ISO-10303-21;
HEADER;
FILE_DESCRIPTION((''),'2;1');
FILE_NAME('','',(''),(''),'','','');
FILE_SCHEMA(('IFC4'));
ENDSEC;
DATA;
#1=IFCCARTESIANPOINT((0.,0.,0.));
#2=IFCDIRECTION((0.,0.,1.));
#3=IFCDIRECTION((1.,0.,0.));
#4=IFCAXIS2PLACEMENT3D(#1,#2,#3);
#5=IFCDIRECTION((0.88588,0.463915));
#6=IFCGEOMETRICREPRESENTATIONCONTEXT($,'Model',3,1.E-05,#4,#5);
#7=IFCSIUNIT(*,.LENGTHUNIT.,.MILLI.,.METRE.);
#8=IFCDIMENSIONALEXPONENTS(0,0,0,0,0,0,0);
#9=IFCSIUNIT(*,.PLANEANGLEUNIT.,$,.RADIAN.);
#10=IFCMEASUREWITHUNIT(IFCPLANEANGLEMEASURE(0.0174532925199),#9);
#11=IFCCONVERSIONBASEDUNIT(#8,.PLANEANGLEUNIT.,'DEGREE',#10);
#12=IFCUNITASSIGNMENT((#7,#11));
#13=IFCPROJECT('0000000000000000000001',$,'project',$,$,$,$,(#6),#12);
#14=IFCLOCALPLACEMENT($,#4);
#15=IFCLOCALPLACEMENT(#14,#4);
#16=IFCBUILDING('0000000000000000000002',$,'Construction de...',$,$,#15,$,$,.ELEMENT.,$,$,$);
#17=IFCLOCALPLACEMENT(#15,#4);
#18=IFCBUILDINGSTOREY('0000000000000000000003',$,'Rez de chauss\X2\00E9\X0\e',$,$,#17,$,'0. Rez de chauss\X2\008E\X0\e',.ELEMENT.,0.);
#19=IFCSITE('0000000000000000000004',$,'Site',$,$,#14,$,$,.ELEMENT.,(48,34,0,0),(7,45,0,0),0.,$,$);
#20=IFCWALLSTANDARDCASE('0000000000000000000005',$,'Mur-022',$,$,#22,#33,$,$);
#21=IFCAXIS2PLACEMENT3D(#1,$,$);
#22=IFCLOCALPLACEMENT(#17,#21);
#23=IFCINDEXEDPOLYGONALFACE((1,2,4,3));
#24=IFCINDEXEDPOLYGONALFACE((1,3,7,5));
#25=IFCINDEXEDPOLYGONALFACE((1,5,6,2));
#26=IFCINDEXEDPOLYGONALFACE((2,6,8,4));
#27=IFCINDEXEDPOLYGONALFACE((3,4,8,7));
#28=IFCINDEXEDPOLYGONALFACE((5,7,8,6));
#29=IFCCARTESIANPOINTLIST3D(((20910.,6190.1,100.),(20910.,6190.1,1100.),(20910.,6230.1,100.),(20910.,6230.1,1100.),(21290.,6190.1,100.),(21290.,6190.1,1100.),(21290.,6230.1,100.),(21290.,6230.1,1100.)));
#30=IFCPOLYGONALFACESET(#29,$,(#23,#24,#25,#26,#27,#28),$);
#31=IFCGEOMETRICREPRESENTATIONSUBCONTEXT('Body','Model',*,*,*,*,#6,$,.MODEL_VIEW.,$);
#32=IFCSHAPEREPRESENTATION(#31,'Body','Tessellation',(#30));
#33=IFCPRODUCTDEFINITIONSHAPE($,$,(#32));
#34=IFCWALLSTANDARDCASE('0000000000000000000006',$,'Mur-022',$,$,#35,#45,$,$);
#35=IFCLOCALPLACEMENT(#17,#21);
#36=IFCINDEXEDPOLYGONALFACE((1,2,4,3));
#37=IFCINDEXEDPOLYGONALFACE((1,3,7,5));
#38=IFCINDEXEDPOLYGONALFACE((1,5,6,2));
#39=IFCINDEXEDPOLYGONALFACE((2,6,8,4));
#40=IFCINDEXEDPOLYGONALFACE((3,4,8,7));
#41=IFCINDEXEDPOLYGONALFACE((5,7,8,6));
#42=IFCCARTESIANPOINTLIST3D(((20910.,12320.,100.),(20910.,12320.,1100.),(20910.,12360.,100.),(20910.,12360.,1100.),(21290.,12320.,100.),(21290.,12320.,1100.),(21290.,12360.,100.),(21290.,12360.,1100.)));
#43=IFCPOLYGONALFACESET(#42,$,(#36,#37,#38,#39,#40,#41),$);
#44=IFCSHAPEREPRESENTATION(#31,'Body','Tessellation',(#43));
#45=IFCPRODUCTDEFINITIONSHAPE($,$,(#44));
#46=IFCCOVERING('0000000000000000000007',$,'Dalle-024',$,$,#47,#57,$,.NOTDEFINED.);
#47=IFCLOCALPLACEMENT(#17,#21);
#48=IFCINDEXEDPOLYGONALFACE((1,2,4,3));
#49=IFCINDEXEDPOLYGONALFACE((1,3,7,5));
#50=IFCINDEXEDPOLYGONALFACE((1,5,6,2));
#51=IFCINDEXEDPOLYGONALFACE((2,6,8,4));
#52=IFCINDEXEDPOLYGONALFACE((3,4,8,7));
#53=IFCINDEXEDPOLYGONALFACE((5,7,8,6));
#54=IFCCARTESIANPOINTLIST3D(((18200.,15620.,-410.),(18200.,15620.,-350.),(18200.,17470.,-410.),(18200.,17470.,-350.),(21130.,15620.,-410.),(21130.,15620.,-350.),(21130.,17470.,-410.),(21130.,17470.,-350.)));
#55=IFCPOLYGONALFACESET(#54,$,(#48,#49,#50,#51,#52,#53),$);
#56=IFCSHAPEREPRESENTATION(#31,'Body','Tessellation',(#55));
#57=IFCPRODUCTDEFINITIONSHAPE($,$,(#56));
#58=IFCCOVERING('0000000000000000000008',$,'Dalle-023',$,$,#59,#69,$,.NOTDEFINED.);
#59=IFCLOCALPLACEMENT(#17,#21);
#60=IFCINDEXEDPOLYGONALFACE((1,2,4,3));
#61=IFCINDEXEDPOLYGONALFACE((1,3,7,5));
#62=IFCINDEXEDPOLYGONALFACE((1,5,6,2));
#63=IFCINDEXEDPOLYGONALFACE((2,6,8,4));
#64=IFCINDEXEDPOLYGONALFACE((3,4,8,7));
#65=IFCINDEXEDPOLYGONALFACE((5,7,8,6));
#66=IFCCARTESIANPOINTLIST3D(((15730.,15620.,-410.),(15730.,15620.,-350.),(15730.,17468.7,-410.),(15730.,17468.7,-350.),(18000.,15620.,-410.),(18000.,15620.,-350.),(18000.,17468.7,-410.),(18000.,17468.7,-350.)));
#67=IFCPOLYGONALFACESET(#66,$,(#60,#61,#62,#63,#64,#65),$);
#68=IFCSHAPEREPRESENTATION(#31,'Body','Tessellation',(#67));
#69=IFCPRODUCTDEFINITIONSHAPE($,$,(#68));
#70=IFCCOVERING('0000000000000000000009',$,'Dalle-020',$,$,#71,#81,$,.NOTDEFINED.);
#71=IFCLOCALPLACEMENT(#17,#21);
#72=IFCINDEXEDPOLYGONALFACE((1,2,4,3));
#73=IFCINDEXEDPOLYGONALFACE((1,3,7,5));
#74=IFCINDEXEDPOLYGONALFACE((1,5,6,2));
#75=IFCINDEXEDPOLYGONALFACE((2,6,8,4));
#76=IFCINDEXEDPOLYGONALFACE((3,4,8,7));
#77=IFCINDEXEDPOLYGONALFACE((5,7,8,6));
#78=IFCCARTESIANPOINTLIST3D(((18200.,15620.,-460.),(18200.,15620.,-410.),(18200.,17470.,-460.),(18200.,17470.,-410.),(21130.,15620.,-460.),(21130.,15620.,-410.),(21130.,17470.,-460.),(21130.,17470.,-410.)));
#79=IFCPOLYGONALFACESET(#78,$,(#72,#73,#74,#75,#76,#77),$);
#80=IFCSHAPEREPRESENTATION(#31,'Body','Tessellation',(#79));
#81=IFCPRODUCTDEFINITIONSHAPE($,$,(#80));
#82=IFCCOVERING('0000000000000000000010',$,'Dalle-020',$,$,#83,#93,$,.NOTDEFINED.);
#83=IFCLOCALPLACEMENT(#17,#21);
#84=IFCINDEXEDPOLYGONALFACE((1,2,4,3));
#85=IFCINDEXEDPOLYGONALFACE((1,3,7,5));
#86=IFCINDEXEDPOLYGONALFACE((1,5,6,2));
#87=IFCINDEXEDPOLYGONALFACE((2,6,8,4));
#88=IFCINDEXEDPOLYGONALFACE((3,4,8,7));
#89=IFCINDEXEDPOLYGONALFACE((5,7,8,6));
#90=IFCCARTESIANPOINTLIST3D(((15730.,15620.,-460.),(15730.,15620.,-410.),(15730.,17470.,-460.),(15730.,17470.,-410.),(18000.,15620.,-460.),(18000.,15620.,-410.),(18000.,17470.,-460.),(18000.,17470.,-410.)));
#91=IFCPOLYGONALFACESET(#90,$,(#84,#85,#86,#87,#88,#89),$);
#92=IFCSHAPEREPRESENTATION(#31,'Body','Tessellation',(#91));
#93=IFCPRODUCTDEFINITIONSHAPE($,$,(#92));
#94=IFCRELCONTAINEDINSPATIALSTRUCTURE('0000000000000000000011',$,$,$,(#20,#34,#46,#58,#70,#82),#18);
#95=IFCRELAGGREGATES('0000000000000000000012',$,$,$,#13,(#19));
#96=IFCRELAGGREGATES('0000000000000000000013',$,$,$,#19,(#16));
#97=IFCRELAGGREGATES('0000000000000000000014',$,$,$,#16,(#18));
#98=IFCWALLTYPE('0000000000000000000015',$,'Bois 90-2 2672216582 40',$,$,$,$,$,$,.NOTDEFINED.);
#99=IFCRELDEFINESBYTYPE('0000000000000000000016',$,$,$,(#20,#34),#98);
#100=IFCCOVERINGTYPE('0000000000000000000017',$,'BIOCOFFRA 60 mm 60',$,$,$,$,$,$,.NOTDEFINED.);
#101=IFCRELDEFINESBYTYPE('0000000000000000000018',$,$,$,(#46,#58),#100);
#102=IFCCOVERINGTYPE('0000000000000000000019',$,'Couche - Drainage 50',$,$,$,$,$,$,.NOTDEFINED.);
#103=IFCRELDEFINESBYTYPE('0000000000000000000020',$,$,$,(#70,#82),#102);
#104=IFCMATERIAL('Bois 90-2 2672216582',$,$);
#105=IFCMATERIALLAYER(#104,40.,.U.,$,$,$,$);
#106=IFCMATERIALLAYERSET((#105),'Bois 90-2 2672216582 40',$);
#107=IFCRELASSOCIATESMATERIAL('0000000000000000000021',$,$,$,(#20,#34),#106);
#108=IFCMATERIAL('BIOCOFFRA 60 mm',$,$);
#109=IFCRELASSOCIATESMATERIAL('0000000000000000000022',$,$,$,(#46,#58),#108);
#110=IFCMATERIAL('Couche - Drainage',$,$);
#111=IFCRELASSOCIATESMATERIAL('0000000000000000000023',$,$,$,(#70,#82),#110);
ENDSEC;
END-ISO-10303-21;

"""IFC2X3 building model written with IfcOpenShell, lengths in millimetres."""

from ifc_helpers import new_model, entity, si_unit, converted_unit, direction, frame, origin_with_axes, place, context, subcontext, project, spatial, polyline, outline, extrude, material, layer, layer_set, layer_usage, type_object, element, save


model = new_model("IFC2X3")

# Units and contexts
model_context = context("Model", 3, precision=1e-05, world=origin_with_axes(), true_north=direction((0.88588, 0.463915)))
body_context = subcontext(model_context, "Body", "Model", "MODEL_VIEW")
ifc_project = project(units=[si_unit("LENGTHUNIT", "METRE", prefix="MILLI"), converted_unit("PLANEANGLEUNIT", "DEGREE", entity("IfcPlaneAngleMeasure", 0.0174532925199), si_unit("PLANEANGLEUNIT", "RADIAN"), dimensions=[0, 0, 0, 0, 0, 0, 0])], contexts=[model_context])

# Site, building, storey
site_placement = place(None, origin_with_axes())
site = spatial("IfcSite", under=ifc_project, at=site_placement, Name="Site", CompositionType="ELEMENT", RefLatitude=(48, 34, 0, 0), RefLongitude=(7, 45, 0, 0), RefElevation=0.0)
building_placement = place(site_placement, origin_with_axes())
building = spatial("IfcBuilding", under=site, at=building_placement, Name="Construction de...", CompositionType="ELEMENT")
storey_placement = place(building_placement, origin_with_axes())
storey = spatial("IfcBuildingStorey", under=building, at=storey_placement, Name="Rez de chaussée", LongName="0. Rez de chauss\u008ee", CompositionType="ELEMENT", Elevation=0.0)

# Walls
ifc_material_1 = material(Name="Bois 90-2 2672216582")
ifc_layer_1 = layer(ifc_material_1, 40.0, ventilated="UNKNOWN")
ifc_layer_set_1 = layer_set([ifc_layer_1], Name="Bois 90-2 2672216582 40")
wall_type_1 = type_object("IfcWallType", Name="Bois 90-2 2672216582 40", PredefinedType="NOTDEFINED")
ifc_layer_usage_1 = layer_usage(ifc_layer_set_1, "AXIS2", "POSITIVE", -20.0)
wall_1_placement = place(storey_placement, frame((20910.0, 6210.1, 100.0), z_axis=(0.0, 0.0, 1.0), x_axis=(1.0, 0.0, 0.0)))
element("IfcWallStandardCase", 1, at=wall_1_placement, inside=storey, type_object=wall_type_1, material=ifc_layer_usage_1, Name="Mur-022", context=body_context, shape_type="SweptSolid", body=[
    extrude(outline(polyline([(0.0, -20.0), (380.0, -20.0), (380.0, 20.0), (0.0, 20.0), (0.0, -20.0)])), origin_with_axes(), (0.0, 0.0, 1.0), 1000.0),
])
ifc_layer_usage_2 = layer_usage(ifc_layer_set_1, "AXIS2", "POSITIVE", -20.0)
wall_2_placement = place(storey_placement, frame((20910.0, 12340.0, 100.0), z_axis=(0.0, 0.0, 1.0), x_axis=(1.0, 0.0, 0.0)))
element("IfcWallStandardCase", 2, at=wall_2_placement, inside=storey, type_object=wall_type_1, material=ifc_layer_usage_2, Name="Mur-022", context=body_context, shape_type="SweptSolid", body=[
    extrude(outline(polyline([(0.0, -20.0), (380.0, -20.0), (380.0, 20.0), (0.0, 20.0), (0.0, -20.0)])), origin_with_axes(), (0.0, 0.0, 1.0), 1000.0),
])

# Coverings
ifc_material_2 = material(Name="BIOCOFFRA 60 mm")
covering_type_1 = type_object("IfcCoveringType", Name="BIOCOFFRA 60 mm 60", PredefinedType="NOTDEFINED")
covering_1_placement = place(storey_placement, frame((18200.0, 15620.0, -350.0), z_axis=(0.0, 0.0, 1.0), x_axis=(1.0, 0.0, 0.0)))
element("IfcCovering", 3, at=covering_1_placement, inside=storey, type_object=covering_type_1, material=ifc_material_2, Name="Dalle-024", PredefinedType="NOTDEFINED", context=body_context, shape_type="SweptSolid", body=[
    extrude(outline(polyline([(0.0, 0.0), (2930.0, 0.0), (2930.0, 1850.0), (0.0, 1850.0), (0.0, 0.0)])), frame((0.0, 0.0, -60.0), z_axis=(0.0, 0.0, 1.0), x_axis=(1.0, 0.0, 0.0)), (0.0, 0.0, 1.0), 60.0),
])
covering_2_placement = place(storey_placement, frame((15730.0, 15620.0, -350.0), z_axis=(0.0, 0.0, 1.0), x_axis=(1.0, 0.0, 0.0)))
element("IfcCovering", 4, at=covering_2_placement, inside=storey, type_object=covering_type_1, material=ifc_material_2, Name="Dalle-023", PredefinedType="NOTDEFINED", context=body_context, shape_type="SweptSolid", body=[
    extrude(outline(polyline([(0.0, 0.0), (2270.0, 0.0), (2270.0, 1848.7), (0.0, 1848.7), (0.0, 0.0)])), frame((0.0, 0.0, -60.0), z_axis=(0.0, 0.0, 1.0), x_axis=(1.0, 0.0, 0.0)), (0.0, 0.0, 1.0), 60.0),
])
ifc_material_3 = material(Name="Couche - Drainage")
covering_type_2 = type_object("IfcCoveringType", Name="Couche - Drainage 50", PredefinedType="NOTDEFINED")
covering_3_placement = place(storey_placement, frame((18200.0, 15620.0, -410.0), z_axis=(0.0, 0.0, 1.0), x_axis=(1.0, 0.0, 0.0)))
element("IfcCovering", 5, at=covering_3_placement, inside=storey, type_object=covering_type_2, material=ifc_material_3, Name="Dalle-020", PredefinedType="NOTDEFINED", context=body_context, shape_type="SweptSolid", body=[
    extrude(outline(polyline([(0.0, 0.0), (2930.0, 0.0), (2930.0, 1850.0), (0.0, 1850.0), (0.0, 0.0)])), frame((0.0, 0.0, -50.0), z_axis=(0.0, 0.0, 1.0), x_axis=(1.0, 0.0, 0.0)), (0.0, 0.0, 1.0), 50.0),
])
covering_4_placement = place(storey_placement, frame((15730.0, 15620.0, -410.0), z_axis=(0.0, 0.0, 1.0), x_axis=(1.0, 0.0, 0.0)))
element("IfcCovering", 6, at=covering_4_placement, inside=storey, type_object=covering_type_2, material=ifc_material_3, Name="Dalle-020", PredefinedType="NOTDEFINED", context=body_context, shape_type="SweptSolid", body=[
    extrude(outline(polyline([(0.0, 0.0), (2270.0, 0.0), (2270.0, 1850.0), (0.0, 1850.0), (0.0, 0.0)])), frame((0.0, 0.0, -50.0), z_axis=(0.0, 0.0, 1.0), x_axis=(1.0, 0.0, 0.0)), (0.0, 0.0, 1.0), 50.0),
])

save(model, "model.ifc")
